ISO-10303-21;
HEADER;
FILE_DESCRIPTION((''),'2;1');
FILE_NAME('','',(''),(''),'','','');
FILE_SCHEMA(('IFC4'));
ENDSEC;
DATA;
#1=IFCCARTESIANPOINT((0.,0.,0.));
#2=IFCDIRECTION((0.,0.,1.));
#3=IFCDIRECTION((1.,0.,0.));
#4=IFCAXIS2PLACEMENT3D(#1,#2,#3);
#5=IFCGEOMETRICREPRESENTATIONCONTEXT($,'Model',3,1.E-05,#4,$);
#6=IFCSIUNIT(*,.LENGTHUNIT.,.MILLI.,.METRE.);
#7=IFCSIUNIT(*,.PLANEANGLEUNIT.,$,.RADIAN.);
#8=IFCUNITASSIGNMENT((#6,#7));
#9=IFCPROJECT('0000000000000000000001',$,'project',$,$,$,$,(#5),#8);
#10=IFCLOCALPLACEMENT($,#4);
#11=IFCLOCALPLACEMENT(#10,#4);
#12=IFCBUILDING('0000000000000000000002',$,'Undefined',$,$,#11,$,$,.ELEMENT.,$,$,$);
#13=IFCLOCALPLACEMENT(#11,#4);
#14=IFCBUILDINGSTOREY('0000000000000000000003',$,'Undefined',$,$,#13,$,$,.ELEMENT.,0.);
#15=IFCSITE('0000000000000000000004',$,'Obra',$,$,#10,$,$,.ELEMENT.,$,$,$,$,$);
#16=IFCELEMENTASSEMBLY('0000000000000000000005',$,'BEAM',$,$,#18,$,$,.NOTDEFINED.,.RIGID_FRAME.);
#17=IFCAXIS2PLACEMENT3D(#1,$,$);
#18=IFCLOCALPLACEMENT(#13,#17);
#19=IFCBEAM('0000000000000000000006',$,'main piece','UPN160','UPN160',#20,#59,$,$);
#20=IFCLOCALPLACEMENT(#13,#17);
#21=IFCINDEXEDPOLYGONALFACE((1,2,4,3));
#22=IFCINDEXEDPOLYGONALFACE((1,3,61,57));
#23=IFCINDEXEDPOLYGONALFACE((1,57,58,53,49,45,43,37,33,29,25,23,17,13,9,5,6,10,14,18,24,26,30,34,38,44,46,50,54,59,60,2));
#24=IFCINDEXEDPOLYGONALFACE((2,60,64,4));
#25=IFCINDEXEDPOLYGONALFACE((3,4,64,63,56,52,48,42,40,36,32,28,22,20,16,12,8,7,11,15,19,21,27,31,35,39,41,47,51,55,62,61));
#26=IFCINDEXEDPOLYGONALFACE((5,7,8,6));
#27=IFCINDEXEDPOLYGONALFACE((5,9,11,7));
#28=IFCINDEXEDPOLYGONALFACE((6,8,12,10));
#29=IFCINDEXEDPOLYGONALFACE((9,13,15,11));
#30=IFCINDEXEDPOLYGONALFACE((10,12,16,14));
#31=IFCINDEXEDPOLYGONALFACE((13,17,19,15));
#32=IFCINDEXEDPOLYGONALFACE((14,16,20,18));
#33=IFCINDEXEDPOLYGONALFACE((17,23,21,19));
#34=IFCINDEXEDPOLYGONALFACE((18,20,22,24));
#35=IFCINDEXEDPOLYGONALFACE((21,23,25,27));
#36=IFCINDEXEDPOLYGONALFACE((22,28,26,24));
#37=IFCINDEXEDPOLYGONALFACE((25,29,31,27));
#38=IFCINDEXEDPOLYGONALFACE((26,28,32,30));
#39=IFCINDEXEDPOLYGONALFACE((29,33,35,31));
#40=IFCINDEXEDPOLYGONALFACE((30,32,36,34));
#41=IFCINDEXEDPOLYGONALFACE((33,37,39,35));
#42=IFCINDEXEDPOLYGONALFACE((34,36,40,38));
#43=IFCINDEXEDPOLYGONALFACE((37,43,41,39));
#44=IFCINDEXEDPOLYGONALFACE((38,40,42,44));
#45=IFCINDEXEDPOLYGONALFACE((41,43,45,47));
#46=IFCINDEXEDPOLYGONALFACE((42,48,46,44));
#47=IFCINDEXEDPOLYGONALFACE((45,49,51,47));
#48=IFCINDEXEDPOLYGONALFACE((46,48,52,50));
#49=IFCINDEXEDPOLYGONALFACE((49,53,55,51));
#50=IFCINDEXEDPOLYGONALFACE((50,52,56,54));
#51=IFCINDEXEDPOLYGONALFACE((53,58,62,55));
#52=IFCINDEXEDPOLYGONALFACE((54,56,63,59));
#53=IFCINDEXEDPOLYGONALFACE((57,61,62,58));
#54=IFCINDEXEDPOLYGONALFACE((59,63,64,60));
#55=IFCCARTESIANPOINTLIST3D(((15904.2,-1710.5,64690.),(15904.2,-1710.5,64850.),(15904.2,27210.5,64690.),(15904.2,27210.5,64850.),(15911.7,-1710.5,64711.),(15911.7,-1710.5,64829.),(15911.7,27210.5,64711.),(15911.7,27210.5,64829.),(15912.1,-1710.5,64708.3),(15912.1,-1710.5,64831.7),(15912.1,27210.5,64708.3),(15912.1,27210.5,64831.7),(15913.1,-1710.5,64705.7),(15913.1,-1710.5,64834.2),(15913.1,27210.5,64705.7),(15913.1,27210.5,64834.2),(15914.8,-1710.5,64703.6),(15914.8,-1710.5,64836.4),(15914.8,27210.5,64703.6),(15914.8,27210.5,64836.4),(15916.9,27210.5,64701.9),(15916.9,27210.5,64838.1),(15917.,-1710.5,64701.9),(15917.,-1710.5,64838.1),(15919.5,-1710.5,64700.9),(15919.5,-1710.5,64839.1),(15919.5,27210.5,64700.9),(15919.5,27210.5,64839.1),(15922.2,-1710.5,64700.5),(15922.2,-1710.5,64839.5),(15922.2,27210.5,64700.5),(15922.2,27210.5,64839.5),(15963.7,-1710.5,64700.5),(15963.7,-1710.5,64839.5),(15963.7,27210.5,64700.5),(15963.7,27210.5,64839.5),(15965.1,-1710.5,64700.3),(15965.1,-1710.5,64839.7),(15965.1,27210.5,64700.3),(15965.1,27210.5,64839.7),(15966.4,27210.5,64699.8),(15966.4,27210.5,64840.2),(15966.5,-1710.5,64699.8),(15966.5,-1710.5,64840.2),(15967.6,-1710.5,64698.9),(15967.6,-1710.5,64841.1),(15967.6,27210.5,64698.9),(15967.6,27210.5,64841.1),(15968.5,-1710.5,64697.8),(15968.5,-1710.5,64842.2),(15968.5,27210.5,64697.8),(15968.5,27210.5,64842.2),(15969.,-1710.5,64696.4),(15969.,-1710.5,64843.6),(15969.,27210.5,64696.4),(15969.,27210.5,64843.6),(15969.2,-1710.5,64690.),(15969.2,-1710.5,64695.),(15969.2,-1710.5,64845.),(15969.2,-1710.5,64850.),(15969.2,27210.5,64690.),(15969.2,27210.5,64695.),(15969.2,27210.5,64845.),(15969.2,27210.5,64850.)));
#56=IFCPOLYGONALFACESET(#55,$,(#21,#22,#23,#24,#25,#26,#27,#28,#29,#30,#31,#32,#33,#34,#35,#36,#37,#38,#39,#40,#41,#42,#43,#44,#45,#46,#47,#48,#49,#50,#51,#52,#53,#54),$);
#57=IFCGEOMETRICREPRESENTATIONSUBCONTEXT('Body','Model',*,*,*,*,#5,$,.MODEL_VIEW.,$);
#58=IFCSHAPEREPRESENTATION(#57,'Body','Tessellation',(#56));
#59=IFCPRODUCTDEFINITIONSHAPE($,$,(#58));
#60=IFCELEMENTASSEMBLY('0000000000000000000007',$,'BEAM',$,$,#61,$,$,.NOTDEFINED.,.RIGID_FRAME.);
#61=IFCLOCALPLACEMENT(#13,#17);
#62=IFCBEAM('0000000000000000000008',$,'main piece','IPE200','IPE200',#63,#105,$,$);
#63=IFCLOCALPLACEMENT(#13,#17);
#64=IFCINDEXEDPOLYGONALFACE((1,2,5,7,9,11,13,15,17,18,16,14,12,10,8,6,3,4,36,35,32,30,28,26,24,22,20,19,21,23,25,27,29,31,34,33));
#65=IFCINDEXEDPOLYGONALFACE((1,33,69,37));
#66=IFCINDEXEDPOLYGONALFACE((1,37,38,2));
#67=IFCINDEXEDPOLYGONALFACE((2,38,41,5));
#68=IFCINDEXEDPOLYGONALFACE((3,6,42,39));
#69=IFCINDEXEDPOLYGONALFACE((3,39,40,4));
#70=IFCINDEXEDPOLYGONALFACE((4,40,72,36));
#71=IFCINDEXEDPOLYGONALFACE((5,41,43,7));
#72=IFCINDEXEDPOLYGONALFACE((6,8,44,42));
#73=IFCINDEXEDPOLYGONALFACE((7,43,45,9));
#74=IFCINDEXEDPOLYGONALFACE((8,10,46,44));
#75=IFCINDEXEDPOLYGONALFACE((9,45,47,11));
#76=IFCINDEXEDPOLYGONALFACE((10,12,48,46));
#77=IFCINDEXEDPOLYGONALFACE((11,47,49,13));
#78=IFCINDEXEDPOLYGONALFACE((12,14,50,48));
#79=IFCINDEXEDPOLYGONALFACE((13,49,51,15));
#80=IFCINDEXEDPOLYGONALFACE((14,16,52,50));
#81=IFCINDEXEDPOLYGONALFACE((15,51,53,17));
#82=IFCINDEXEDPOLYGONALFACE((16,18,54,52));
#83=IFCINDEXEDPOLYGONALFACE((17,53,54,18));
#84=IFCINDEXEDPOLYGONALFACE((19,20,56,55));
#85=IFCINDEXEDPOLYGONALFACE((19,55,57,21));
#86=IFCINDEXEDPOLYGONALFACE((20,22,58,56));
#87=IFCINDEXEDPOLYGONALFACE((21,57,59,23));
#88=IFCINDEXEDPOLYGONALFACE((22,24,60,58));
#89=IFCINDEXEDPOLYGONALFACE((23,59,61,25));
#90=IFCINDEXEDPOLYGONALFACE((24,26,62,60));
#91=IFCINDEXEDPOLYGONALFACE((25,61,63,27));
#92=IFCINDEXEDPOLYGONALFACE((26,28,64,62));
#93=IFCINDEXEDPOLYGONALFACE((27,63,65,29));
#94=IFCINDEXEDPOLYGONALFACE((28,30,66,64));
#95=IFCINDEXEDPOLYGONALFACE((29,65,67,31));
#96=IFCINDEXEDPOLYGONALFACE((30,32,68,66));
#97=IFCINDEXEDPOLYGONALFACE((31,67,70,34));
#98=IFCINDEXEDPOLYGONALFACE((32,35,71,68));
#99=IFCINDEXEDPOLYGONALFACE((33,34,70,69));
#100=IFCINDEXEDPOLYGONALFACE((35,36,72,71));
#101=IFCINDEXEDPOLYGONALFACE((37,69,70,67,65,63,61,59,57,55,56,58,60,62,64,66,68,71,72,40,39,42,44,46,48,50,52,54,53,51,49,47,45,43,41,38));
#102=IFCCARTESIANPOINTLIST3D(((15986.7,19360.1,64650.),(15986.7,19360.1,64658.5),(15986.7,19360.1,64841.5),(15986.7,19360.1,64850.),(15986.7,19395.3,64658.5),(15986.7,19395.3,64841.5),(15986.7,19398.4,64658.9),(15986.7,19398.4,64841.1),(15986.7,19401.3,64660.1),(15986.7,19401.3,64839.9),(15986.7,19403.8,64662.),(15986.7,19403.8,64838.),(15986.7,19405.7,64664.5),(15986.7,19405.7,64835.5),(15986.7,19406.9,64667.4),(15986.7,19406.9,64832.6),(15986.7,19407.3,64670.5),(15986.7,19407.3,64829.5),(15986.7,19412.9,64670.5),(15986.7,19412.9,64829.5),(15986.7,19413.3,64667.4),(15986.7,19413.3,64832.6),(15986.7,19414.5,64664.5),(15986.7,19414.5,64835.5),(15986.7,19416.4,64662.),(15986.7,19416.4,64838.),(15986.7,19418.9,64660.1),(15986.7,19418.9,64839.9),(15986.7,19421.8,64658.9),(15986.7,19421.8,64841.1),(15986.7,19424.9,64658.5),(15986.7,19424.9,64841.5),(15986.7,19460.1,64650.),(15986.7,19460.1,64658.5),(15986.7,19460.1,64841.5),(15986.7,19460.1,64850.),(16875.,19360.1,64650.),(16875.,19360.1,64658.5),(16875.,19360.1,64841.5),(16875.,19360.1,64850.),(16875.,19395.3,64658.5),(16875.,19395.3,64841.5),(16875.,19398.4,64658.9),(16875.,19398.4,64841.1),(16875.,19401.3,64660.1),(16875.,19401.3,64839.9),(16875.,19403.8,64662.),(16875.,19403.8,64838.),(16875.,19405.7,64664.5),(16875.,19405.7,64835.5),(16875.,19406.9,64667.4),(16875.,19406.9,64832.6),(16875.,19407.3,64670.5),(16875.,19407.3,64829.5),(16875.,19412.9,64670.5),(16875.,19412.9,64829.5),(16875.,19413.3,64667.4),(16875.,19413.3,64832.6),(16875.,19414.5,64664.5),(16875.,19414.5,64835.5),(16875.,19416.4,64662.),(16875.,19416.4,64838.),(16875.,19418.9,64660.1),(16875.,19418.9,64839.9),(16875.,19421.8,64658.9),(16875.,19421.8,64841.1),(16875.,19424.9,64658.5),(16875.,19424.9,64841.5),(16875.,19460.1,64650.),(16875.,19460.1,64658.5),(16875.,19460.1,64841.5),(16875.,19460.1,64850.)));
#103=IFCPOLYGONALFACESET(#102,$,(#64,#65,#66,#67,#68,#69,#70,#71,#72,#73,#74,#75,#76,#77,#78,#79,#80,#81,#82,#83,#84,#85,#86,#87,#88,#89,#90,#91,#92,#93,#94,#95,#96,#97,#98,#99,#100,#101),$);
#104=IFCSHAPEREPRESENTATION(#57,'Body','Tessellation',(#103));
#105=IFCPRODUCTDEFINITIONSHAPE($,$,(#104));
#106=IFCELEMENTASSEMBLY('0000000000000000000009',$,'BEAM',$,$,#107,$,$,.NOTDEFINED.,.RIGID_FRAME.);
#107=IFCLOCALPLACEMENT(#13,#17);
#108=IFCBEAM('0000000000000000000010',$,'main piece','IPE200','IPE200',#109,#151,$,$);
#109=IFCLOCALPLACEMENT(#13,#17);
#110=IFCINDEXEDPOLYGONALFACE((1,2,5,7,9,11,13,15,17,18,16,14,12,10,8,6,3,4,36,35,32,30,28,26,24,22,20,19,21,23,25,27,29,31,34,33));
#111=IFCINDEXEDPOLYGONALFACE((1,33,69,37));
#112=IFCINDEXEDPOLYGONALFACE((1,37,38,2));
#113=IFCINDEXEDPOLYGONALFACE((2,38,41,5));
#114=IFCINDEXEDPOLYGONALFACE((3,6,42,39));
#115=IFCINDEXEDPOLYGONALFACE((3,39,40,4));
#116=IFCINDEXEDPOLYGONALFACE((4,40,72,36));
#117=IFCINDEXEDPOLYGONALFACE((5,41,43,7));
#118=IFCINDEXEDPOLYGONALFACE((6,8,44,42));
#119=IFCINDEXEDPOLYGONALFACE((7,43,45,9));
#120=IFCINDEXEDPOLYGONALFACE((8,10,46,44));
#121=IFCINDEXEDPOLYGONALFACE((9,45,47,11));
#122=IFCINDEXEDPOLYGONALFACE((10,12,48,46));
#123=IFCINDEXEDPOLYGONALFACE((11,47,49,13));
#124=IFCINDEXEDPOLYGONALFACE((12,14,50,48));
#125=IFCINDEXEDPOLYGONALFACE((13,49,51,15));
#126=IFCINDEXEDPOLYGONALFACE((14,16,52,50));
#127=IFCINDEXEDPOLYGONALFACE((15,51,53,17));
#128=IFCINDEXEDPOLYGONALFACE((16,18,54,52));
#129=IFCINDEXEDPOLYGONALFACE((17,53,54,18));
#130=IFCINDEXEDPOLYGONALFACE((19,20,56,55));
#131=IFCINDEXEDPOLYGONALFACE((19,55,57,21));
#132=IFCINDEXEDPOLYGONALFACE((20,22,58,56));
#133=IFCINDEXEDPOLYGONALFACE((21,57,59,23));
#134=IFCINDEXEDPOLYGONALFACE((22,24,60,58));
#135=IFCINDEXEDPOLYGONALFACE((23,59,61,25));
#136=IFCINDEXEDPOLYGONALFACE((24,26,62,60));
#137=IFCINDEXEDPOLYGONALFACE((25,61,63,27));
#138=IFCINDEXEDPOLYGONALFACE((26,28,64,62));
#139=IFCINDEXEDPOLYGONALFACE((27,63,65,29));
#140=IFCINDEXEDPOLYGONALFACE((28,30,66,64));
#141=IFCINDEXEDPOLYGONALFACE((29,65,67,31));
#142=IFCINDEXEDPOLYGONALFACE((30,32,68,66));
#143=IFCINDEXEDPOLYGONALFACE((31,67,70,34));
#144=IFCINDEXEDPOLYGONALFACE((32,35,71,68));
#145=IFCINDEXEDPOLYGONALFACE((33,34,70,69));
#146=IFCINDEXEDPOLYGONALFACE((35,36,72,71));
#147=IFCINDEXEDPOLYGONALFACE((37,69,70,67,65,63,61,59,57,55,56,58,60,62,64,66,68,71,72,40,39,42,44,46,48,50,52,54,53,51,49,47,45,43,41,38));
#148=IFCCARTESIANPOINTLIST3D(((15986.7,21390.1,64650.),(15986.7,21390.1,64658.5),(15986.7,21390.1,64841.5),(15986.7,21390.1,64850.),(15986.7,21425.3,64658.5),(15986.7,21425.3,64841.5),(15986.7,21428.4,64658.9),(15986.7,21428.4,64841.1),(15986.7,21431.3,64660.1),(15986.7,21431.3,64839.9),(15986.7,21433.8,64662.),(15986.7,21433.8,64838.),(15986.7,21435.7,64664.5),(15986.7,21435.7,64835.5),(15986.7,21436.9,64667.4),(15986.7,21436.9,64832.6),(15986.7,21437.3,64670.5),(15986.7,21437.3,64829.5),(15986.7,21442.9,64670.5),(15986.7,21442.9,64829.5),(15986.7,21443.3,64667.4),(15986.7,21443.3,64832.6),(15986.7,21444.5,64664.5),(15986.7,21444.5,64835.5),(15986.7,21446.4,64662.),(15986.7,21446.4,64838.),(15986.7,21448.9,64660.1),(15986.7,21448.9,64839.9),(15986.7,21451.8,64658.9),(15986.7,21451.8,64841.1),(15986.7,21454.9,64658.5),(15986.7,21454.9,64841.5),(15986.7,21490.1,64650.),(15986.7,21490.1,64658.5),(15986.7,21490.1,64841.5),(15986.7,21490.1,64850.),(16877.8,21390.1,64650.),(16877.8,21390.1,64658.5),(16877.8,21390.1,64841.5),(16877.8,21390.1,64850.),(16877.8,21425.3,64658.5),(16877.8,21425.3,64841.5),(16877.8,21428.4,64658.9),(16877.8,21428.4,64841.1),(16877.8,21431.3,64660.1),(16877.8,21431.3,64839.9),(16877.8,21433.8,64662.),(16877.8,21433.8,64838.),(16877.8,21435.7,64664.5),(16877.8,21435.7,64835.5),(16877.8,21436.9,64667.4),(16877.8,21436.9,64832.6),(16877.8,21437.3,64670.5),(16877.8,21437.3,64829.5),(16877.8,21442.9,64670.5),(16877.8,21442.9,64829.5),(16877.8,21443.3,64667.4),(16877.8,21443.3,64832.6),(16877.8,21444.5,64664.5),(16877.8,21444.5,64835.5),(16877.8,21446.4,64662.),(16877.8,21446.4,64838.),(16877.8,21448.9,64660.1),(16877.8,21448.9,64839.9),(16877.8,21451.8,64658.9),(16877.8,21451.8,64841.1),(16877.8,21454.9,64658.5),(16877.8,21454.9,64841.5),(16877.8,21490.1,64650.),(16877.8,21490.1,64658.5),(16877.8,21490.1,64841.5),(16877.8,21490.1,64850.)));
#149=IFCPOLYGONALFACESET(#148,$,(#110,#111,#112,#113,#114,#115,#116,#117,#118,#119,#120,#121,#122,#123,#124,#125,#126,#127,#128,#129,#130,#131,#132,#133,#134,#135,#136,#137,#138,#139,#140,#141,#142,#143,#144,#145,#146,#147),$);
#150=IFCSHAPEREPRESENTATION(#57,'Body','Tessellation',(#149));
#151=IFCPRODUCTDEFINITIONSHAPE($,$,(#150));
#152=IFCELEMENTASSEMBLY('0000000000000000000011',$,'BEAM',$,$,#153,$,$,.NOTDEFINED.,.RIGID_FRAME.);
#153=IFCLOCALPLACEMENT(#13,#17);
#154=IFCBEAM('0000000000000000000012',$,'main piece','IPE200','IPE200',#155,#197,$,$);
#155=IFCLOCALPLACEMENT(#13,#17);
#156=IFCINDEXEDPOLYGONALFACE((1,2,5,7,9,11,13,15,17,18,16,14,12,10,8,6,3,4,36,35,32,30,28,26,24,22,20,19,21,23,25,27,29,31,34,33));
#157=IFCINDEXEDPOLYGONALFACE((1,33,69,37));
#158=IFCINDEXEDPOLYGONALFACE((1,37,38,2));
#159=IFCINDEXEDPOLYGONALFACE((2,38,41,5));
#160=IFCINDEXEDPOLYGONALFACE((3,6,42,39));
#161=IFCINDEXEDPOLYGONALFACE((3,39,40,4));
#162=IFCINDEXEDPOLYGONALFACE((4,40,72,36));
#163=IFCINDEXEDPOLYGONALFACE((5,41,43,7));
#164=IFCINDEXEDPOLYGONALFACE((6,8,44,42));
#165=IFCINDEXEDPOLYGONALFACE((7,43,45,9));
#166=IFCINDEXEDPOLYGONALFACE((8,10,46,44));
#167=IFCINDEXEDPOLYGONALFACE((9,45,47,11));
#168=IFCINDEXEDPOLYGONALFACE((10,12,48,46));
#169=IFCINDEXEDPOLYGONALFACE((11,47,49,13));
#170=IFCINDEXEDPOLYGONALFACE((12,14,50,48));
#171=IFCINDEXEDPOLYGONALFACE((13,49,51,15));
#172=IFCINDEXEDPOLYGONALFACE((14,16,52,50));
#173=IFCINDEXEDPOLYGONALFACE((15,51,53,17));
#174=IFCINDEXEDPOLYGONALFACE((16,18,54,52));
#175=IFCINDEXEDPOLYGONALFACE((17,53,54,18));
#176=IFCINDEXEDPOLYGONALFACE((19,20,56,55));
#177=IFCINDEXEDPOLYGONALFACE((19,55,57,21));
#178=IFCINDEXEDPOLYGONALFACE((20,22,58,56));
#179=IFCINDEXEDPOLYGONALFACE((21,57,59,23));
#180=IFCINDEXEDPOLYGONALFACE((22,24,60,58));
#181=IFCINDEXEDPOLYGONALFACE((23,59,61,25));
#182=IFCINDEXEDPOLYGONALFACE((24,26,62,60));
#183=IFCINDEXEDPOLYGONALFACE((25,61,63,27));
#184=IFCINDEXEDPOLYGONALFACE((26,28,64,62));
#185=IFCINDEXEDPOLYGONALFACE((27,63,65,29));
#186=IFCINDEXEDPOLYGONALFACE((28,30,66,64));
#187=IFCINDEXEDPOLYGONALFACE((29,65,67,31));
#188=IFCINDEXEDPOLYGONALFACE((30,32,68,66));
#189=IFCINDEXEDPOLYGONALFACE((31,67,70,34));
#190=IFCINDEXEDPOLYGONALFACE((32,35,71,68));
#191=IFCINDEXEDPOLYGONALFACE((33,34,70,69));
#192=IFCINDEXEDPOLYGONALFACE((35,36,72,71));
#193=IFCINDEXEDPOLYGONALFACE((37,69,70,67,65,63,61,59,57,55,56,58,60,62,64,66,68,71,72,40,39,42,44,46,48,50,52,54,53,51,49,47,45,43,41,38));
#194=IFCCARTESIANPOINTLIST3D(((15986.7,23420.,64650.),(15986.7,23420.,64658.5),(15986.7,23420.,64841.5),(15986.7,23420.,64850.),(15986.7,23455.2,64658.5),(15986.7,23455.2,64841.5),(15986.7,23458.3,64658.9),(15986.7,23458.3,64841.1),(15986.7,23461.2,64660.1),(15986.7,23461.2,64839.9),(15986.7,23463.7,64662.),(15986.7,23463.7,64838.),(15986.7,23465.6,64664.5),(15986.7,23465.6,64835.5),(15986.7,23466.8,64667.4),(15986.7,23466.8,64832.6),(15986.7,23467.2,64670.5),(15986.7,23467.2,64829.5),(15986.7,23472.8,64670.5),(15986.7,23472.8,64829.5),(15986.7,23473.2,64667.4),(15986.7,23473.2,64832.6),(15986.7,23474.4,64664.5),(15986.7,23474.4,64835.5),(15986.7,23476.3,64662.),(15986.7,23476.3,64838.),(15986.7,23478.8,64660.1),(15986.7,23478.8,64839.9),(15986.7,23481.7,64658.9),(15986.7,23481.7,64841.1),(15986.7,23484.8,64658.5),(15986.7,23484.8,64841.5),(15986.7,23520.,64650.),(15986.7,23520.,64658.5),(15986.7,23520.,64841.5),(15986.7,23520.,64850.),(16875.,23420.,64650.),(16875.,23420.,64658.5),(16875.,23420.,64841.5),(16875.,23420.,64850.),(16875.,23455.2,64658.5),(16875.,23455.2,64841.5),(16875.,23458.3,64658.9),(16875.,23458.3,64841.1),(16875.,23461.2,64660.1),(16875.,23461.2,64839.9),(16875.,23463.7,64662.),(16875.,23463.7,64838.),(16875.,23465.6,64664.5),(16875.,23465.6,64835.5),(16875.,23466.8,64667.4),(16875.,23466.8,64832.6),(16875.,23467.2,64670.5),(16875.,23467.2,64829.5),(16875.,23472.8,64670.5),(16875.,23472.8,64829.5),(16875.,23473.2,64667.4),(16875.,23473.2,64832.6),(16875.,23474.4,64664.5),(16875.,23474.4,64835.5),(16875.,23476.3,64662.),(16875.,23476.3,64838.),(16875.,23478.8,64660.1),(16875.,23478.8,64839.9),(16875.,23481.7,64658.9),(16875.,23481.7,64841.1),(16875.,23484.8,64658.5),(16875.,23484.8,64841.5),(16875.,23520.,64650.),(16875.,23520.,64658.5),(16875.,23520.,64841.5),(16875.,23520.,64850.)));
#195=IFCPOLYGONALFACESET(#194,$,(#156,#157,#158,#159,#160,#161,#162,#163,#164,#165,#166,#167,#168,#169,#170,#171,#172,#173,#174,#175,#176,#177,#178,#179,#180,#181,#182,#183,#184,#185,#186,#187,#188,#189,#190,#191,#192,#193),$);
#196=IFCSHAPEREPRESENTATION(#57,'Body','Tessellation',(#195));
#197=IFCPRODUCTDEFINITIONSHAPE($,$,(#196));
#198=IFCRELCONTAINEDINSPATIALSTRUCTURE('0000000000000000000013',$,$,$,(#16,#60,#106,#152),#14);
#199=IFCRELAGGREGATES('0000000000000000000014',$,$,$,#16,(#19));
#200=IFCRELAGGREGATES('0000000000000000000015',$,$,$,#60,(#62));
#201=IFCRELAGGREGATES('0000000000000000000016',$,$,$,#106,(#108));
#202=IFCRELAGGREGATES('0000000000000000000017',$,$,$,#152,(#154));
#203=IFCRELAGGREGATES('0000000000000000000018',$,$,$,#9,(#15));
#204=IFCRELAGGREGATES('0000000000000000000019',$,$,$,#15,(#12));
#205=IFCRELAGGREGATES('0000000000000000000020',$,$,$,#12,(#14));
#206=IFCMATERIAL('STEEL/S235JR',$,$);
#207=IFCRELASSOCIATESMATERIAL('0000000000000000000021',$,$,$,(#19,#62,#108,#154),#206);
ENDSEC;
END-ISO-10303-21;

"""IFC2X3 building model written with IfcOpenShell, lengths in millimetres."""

from ifc_helpers import new_model, si_unit, frame, origin_with_axes, origin_2d_with_axis, place, context, subcontext, project, spatial, i_section, u_section, extrude, material, element, aggregate, save


model = new_model("IFC2X3")

# Units and contexts
model_context = context("Model", 3, precision=1e-05, world=origin_with_axes())
body_context = subcontext(model_context, "Body", "Model", "MODEL_VIEW")
ifc_project = project(units=[si_unit("LENGTHUNIT", "METRE", prefix="MILLI"), si_unit("PLANEANGLEUNIT", "RADIAN")], contexts=[model_context])

# Site, building, storey
site_placement = place(None, origin_with_axes())
site = spatial("IfcSite", under=ifc_project, at=site_placement, Name="Obra", CompositionType="ELEMENT")
building_placement = place(site_placement, origin_with_axes())
building = spatial("IfcBuilding", under=site, at=building_placement, Name="Undefined", CompositionType="ELEMENT")
storey_placement = place(building_placement, origin_with_axes())
storey = spatial("IfcBuildingStorey", under=building, at=storey_placement, Name="Undefined", CompositionType="ELEMENT", Elevation=0.0)

# Shared definitions
ifc_material_1 = material(Name="STEEL/S235JR")

# Element assemblies, beams
assembly_1_placement = place(storey_placement, origin_with_axes())
assembly_1 = element("IfcElementAssembly", 1, at=assembly_1_placement, inside=storey, Name="BEAM", AssemblyPlace="NOTDEFINED", PredefinedType="RIGID_FRAME")
beam_1_placement = place(assembly_1_placement, frame((15936.7, 27210.5, 64770.0), z_axis=(0.0, 0.0, -1.0), x_axis=(0.0, -1.0, 0.0)))
beam_1 = element("IfcBeam", 2, at=beam_1_placement, material=ifc_material_1, Name="main piece", Description="UPN160", ObjectType="UPN160", context=body_context, shape_type="SweptSolid", body=[
    extrude(u_section(Depth=160.0, FlangeWidth=65.0, WebThickness=7.5, FlangeThickness=10.5, FilletRadius=10.5, EdgeRadius=5.5, at=origin_2d_with_axis()), frame((28921.0, 0.0, 0.0), z_axis=(-1.0, 0.0, 0.0), x_axis=(0.0, -1.0, 0.0)), (0.0, 0.0, 1.0), 28921.0),
])
aggregate(assembly_1, [beam_1])
assembly_2_placement = place(storey_placement, origin_with_axes())
assembly_2 = element("IfcElementAssembly", 3, at=assembly_2_placement, inside=storey, Name="BEAM", AssemblyPlace="NOTDEFINED", PredefinedType="RIGID_FRAME")
beam_2_placement = place(assembly_2_placement, frame((15986.7, 19410.1, 64750.0), z_axis=(0.0, 0.0, 1.0), x_axis=(1.0, 0.0, 0.0)))
beam_2 = element("IfcBeam", 4, at=beam_2_placement, material=ifc_material_1, Name="main piece", Description="IPE200", ObjectType="IPE200", context=body_context, shape_type="SweptSolid", body=[
    extrude(i_section(OverallWidth=100.0, OverallDepth=200.0, WebThickness=5.6, FlangeThickness=8.5, FilletRadius=12.0, at=origin_2d_with_axis()), frame((888.3, 0.0, 0.0), z_axis=(-1.0, 0.0, 0.0), x_axis=(0.0, -1.0, 0.0)), (0.0, 0.0, 1.0), 888.3),
])
aggregate(assembly_2, [beam_2])
assembly_3_placement = place(storey_placement, origin_with_axes())
assembly_3 = element("IfcElementAssembly", 5, at=assembly_3_placement, inside=storey, Name="BEAM", AssemblyPlace="NOTDEFINED", PredefinedType="RIGID_FRAME")
beam_3_placement = place(assembly_3_placement, frame((16877.8, 21440.1, 64750.0), z_axis=(0.0, 0.0, 1.0), x_axis=(-1.0, -0.000037, 0.0)))
beam_3 = element("IfcBeam", 6, at=beam_3_placement, material=ifc_material_1, Name="main piece", Description="IPE200", ObjectType="IPE200", context=body_context, shape_type="SweptSolid", body=[
    extrude(i_section(OverallWidth=100.0, OverallDepth=200.0, WebThickness=5.6, FlangeThickness=8.5, FilletRadius=12.0, at=origin_2d_with_axis()), frame((891.1, 0.0, 0.0), z_axis=(-1.0, 0.0, 0.0), x_axis=(0.0, -1.0, 0.0)), (0.0, 0.0, 1.0), 891.1),
])
aggregate(assembly_3, [beam_3])
assembly_4_placement = place(storey_placement, origin_with_axes())
assembly_4 = element("IfcElementAssembly", 7, at=assembly_4_placement, inside=storey, Name="BEAM", AssemblyPlace="NOTDEFINED", PredefinedType="RIGID_FRAME")
beam_4_placement = place(assembly_4_placement, frame((15986.7, 23470.0, 64750.0), z_axis=(0.0, 0.0, 1.0), x_axis=(1.0, 0.0, 0.0)))
beam_4 = element("IfcBeam", 8, at=beam_4_placement, material=ifc_material_1, Name="main piece", Description="IPE200", ObjectType="IPE200", context=body_context, shape_type="SweptSolid", body=[
    extrude(i_section(OverallWidth=100.0, OverallDepth=200.0, WebThickness=5.6, FlangeThickness=8.5, FilletRadius=12.0, at=origin_2d_with_axis()), frame((888.3, 0.0, 0.0), z_axis=(-1.0, 0.0, 0.0), x_axis=(0.0, -1.0, 0.0)), (0.0, 0.0, 1.0), 888.3),
])
aggregate(assembly_4, [beam_4])

save(model, "model.ifc")
